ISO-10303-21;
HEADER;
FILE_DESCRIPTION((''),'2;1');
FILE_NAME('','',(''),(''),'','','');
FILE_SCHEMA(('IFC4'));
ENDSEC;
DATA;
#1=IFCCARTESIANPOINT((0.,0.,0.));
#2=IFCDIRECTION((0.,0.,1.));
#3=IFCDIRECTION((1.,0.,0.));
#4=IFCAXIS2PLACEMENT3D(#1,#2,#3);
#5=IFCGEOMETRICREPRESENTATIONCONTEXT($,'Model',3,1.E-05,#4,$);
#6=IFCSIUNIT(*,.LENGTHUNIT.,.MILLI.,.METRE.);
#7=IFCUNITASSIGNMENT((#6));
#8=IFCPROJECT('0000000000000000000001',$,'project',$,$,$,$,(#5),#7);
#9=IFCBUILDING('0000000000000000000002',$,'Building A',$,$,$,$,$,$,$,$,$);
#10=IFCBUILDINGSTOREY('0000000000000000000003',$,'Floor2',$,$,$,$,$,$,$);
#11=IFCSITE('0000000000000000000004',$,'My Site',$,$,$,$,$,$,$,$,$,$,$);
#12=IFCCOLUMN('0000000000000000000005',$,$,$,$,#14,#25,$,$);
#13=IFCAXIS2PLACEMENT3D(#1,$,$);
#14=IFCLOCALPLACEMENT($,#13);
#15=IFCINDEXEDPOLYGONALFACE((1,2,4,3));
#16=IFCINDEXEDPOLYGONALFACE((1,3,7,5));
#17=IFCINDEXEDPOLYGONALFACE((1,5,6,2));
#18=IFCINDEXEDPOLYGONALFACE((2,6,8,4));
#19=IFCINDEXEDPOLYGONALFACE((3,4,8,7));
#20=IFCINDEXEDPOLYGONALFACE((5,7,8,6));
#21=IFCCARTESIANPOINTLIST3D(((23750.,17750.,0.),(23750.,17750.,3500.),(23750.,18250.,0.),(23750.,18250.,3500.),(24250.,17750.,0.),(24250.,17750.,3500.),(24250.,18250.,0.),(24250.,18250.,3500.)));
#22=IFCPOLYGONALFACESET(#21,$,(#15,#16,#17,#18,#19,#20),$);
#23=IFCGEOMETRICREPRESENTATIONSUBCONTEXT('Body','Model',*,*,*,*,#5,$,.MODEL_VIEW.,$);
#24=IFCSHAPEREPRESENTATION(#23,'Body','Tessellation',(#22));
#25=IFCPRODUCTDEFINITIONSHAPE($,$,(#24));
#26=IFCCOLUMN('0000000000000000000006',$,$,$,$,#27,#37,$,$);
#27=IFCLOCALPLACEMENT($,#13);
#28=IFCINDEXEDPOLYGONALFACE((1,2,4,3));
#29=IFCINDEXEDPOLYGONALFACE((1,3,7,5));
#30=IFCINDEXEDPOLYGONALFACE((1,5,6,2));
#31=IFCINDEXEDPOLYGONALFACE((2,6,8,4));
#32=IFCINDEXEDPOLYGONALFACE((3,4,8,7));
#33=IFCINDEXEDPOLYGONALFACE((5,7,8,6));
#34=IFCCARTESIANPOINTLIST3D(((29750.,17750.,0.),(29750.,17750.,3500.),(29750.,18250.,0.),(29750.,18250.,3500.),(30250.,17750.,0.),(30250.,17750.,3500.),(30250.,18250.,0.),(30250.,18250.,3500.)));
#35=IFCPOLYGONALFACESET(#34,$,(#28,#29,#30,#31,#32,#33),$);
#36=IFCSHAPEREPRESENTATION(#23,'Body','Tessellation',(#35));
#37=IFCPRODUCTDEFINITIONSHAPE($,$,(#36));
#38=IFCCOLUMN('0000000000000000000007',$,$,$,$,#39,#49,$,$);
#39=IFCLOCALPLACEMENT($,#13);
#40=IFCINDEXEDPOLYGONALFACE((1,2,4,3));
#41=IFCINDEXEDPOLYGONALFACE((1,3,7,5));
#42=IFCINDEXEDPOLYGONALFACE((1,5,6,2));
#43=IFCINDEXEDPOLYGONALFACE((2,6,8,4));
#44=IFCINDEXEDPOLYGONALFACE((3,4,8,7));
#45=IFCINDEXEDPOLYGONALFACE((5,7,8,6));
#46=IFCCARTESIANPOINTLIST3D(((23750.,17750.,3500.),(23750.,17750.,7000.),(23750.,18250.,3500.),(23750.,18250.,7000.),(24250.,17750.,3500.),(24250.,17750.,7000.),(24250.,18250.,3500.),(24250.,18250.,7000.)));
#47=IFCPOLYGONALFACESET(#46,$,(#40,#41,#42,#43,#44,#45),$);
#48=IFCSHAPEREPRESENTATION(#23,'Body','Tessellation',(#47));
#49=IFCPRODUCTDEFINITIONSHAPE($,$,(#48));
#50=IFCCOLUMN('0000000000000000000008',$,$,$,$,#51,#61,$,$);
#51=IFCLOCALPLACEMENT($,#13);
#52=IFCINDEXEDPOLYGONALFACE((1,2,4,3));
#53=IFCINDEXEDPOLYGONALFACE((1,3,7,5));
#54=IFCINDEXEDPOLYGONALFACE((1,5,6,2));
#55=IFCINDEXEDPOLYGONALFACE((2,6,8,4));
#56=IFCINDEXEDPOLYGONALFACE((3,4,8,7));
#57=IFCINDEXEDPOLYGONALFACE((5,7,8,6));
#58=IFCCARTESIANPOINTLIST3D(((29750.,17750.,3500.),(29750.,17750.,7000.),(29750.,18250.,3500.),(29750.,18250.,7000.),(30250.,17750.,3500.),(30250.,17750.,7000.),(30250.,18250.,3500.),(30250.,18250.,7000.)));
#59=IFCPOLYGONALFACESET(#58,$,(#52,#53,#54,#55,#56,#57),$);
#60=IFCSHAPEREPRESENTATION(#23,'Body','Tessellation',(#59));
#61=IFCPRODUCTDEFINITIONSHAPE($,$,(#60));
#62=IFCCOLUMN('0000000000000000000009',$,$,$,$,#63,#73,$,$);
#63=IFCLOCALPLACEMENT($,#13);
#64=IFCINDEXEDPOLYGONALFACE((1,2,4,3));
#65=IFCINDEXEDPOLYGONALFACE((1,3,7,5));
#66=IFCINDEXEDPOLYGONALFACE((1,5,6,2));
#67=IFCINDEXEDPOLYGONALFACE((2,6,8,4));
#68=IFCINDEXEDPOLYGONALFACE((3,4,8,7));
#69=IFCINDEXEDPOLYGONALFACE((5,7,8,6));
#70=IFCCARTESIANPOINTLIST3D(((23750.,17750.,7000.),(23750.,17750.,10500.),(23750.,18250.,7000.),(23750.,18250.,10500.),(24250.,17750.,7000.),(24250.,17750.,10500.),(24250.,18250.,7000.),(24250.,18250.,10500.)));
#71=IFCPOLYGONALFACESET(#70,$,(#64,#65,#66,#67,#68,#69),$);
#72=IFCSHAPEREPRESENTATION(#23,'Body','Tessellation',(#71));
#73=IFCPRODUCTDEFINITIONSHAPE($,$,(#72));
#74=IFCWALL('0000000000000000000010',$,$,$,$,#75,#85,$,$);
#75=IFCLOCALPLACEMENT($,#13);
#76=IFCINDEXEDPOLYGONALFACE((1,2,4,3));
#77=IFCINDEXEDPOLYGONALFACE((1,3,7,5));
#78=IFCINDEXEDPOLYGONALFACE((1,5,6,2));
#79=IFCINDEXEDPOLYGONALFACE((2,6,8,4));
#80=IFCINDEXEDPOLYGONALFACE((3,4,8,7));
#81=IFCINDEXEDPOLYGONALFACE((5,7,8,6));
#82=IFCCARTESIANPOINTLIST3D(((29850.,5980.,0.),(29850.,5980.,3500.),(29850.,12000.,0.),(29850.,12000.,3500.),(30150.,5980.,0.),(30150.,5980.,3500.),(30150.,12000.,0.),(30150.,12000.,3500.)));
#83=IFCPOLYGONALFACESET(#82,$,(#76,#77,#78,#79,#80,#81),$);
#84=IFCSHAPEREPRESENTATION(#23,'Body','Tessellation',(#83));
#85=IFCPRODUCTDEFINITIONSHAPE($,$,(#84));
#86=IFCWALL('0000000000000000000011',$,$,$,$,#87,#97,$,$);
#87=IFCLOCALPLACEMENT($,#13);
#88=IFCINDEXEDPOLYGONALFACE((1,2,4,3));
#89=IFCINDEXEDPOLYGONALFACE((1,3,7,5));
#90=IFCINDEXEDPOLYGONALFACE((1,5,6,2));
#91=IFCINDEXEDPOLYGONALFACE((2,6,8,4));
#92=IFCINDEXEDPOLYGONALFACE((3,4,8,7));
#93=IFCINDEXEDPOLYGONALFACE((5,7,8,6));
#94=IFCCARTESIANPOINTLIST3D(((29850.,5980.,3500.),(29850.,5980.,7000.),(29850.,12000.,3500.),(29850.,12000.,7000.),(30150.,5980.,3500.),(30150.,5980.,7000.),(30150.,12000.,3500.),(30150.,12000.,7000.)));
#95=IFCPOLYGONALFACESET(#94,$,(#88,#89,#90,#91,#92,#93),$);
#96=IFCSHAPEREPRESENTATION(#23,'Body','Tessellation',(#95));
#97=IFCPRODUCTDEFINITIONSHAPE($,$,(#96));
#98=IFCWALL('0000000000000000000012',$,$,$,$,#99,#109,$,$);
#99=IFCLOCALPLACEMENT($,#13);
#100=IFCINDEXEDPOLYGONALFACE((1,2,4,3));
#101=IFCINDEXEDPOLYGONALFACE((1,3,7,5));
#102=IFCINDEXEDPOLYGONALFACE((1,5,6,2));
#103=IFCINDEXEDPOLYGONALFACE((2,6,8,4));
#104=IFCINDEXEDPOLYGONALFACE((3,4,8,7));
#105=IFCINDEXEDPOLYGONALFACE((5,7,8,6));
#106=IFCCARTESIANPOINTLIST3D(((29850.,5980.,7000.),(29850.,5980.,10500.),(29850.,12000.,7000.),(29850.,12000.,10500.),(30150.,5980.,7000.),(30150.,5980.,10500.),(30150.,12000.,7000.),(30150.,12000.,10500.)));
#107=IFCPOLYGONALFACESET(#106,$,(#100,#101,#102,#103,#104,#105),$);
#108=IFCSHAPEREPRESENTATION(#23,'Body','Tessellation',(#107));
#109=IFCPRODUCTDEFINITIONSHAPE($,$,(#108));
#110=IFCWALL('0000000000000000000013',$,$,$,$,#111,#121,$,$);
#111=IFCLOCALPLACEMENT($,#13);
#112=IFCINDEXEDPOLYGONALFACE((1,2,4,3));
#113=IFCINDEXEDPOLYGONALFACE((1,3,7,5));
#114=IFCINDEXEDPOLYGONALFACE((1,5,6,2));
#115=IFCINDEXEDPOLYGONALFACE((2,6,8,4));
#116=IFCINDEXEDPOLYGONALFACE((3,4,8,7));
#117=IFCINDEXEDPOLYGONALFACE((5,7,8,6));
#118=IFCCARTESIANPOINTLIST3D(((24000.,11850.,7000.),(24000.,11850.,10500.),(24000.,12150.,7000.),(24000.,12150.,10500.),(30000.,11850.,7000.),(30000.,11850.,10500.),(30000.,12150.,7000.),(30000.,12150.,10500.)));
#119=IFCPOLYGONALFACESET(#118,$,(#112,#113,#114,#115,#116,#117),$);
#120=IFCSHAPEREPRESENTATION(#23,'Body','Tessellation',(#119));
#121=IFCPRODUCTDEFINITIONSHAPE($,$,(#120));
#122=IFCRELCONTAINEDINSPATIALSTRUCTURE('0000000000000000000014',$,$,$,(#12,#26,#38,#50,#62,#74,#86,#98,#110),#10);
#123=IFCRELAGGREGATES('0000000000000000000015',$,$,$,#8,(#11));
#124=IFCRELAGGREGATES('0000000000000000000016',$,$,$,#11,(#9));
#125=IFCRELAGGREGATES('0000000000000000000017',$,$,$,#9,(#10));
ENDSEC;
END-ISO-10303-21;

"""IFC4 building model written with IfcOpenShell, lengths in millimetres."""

from ifc_helpers import new_model, si_unit, frame, origin_with_axes, place, context, subcontext, project, spatial, line, indexed_curve, outline, extrude, element, save


model = new_model("IFC4")

# Units and contexts
model_context = context("Model", 3, precision=1e-05, world=origin_with_axes())
body_context = subcontext(model_context, "Body", "Model", "MODEL_VIEW")
ifc_project = project(units=[si_unit("LENGTHUNIT", "METRE", prefix="MILLI")], contexts=[model_context])

# Site, building, storey
site = spatial("IfcSite", under=ifc_project, Name="My Site")
building = spatial("IfcBuilding", under=site, Name="Building A")
storey = spatial("IfcBuildingStorey", under=building, Name="Floor2")

# Columns
for number, where, z_axis, x_axis in (
    (1, (24000.0, 18000.0, 0.0), (0.0, 0.0, 1.0), (1.0, 0.0, 0.0)),
    (2, (30000.0, 18000.0, 0.0), (0.0, 0.0, 1.0), (1.0, 0.0, 0.0)),
    (3, (24000.0, 18000.0, 3500.0), (0.0, 0.0, 1.0), (1.0, 0.0, 0.0)),
    (4, (30000.0, 18000.0, 3500.0), (0.0, 0.0, 1.0), (1.0, 0.0, 0.0)),
    (5, (24000.0, 18000.0, 7000.0), (0.0, 0.0, 1.0), (1.0, 0.0, 0.0)),
):
    element("IfcColumn", number, at=place(None, frame(where, z_axis=z_axis, x_axis=x_axis)), inside=storey, context=body_context, shape_type="SweptSolid", body=[
        extrude(outline(indexed_curve([(-250.0, -250.0), (250.0, -250.0), (250.0, 250.0), (-250.0, 250.0)], segments=[line(1, 2, 3, 4, 1)])), origin_with_axes(), (0.0, 0.0, 1.0), 3500.0),
    ])

# Walls
for number, where, z_axis, x_axis in (
    (6, (29850.0, 12000.0, 0.0), (0.0, 0.0, 1.0), (0.0, -1.0, 0.0)),
    (7, (29850.0, 12000.0, 3500.0), (0.0, 0.0, 1.0), (0.0, -1.0, 0.0)),
    (8, (29850.0, 12000.0, 7000.0), (0.0, 0.0, 1.0), (0.0, -1.0, 0.0)),
):
    element("IfcWall", number, at=place(None, frame(where, z_axis=z_axis, x_axis=x_axis)), inside=storey, context=body_context, shape_type="SweptSolid", body=[
        extrude(outline(indexed_curve([(0.0, 0.0), (0.0, 300.0), (6020.0, 300.0), (6020.0, 0.0), (0.0, 0.0)], self_intersect=False)), origin_with_axes(), (0.0, 0.0, 1.0), 3500.0),
    ])
wall_placement = place(None, frame((24000.0, 11850.0, 7000.0), z_axis=(0.0, 0.0, 1.0), x_axis=(1.0, 0.0, 0.0)))
element("IfcWall", 9, at=wall_placement, inside=storey, context=body_context, shape_type="SweptSolid", body=[
    extrude(outline(indexed_curve([(0.0, 0.0), (0.0, 300.0), (6000.0, 300.0), (6000.0, 0.0), (0.0, 0.0)], self_intersect=False)), origin_with_axes(), (0.0, 0.0, 1.0), 3500.0),
])

save(model, "model.ifc")
